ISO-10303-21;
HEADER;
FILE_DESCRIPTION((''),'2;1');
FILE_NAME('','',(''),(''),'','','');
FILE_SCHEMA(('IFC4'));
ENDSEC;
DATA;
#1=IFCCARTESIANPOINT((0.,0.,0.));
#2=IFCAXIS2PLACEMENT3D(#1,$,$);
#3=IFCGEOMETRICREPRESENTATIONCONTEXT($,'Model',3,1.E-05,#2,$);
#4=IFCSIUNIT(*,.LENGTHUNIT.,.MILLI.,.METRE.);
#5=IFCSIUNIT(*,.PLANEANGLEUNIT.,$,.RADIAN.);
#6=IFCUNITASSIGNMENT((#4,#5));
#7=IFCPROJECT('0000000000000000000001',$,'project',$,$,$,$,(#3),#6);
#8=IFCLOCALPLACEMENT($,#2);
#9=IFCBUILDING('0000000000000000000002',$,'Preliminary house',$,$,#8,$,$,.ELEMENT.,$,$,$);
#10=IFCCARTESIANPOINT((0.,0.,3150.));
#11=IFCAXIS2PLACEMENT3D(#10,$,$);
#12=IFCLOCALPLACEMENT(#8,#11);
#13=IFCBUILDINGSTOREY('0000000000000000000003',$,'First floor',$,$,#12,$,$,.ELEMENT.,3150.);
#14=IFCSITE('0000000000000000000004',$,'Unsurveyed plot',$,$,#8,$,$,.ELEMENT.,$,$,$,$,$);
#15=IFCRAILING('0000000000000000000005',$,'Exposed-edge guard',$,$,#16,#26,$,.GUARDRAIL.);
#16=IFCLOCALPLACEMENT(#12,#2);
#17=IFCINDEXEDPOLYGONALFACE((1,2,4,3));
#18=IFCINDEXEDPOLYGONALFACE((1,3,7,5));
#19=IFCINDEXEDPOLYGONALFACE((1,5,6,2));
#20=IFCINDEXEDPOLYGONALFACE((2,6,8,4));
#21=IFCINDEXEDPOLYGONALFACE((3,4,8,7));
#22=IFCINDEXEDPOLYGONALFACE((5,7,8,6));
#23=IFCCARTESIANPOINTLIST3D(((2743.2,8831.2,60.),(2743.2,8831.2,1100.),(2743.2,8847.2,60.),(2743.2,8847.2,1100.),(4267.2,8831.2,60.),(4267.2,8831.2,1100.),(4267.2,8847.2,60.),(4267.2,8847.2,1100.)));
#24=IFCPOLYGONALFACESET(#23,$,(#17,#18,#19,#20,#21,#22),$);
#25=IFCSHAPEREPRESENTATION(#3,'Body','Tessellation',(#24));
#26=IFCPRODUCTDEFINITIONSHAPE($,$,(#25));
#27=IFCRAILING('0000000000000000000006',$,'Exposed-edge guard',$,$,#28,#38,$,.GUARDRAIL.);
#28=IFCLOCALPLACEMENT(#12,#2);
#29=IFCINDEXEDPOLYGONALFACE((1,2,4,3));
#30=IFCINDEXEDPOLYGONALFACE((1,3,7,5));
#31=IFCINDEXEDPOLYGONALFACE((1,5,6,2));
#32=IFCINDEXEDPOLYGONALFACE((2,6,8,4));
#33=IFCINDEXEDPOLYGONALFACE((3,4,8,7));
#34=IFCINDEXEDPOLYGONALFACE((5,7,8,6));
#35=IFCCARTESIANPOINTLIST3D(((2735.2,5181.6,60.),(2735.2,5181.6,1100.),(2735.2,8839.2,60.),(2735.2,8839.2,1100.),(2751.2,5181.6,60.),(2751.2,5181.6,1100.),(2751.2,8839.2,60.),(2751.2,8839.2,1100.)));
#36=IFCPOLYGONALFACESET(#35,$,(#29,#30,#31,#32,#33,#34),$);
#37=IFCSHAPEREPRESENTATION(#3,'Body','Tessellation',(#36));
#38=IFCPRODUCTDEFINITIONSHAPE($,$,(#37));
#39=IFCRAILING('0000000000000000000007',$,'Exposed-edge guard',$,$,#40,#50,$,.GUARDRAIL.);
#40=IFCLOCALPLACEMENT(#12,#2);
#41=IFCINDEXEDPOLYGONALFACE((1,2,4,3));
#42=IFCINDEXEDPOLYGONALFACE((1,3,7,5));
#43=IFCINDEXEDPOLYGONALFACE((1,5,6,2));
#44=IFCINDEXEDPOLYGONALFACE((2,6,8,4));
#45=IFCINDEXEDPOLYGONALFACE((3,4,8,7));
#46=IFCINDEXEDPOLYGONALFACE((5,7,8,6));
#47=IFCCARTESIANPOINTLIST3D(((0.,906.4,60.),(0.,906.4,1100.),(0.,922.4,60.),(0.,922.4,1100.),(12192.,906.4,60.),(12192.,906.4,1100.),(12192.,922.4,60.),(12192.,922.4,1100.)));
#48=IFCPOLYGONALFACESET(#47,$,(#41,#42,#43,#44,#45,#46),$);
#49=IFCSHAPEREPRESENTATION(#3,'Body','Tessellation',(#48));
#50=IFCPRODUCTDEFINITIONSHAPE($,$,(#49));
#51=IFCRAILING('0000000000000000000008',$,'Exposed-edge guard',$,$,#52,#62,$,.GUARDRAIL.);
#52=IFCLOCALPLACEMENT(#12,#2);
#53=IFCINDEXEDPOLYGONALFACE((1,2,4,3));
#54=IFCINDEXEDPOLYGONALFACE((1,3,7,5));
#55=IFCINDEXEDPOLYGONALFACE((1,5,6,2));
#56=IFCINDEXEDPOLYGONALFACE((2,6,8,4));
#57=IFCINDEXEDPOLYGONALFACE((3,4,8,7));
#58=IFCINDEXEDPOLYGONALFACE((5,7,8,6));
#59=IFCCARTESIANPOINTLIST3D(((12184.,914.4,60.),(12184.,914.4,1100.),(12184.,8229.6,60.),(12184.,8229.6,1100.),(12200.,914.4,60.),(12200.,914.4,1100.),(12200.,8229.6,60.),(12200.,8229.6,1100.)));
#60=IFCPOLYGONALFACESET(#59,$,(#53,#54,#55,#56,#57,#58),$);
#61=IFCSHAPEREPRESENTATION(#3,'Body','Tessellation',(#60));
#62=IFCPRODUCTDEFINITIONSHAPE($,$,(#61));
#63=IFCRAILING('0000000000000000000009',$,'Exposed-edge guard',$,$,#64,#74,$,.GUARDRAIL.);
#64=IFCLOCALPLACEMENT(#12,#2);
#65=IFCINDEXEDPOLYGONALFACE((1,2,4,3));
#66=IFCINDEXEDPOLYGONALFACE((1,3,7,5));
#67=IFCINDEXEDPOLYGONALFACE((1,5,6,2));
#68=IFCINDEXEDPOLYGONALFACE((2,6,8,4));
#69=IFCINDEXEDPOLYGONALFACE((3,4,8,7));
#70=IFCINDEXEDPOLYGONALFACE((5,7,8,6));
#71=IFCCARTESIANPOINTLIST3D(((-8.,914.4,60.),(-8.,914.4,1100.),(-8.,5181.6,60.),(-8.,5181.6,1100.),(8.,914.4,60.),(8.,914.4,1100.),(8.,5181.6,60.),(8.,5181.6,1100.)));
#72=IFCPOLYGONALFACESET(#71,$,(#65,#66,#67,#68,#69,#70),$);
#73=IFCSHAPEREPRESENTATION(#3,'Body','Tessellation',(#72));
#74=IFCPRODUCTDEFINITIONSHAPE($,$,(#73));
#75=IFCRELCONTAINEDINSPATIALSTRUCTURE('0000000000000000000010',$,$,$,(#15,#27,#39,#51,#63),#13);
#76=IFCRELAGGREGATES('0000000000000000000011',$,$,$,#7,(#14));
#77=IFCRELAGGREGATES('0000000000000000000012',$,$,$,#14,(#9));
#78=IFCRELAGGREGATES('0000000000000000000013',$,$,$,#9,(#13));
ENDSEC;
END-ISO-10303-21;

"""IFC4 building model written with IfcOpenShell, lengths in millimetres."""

from ifc_helpers import new_model, si_unit, frame, origin, place, context, project, spatial, polyline, outline, extrude, element, save


model = new_model("IFC4")

# Units and contexts
model_context = context("Model", 3, precision=1e-05, world=origin())
ifc_project = project(units=[si_unit("LENGTHUNIT", "METRE", prefix="MILLI"), si_unit("PLANEANGLEUNIT", "RADIAN")], contexts=[model_context])

# Site, building, storey
placement_1 = place(None, origin())
site = spatial("IfcSite", under=ifc_project, at=placement_1, Name="Unsurveyed plot", CompositionType="ELEMENT")
building = spatial("IfcBuilding", under=site, at=placement_1, Name="Preliminary house", CompositionType="ELEMENT")
placement_2 = place(placement_1, frame((0.0, 0.0, 3150.0)))
storey = spatial("IfcBuildingStorey", under=building, at=placement_2, Name="First floor", CompositionType="ELEMENT", Elevation=3150.0)

# Railings
element("IfcRailing", 1, at=placement_2, inside=storey, Name="Exposed-edge guard", PredefinedType="GUARDRAIL", context=model_context, shape_type="SweptSolid", body=[
    extrude(outline(polyline([(2743.2, 8831.2), (2743.2, 8847.2), (4267.2, 8847.2), (4267.2, 8831.2), (2743.2, 8831.2)])), frame((0.0, 0.0, 60.0)), (0.0, 0.0, 1.0), 1040.0),
])
element("IfcRailing", 2, at=placement_2, inside=storey, Name="Exposed-edge guard", PredefinedType="GUARDRAIL", context=model_context, shape_type="SweptSolid", body=[
    extrude(outline(polyline([(2751.2, 5181.6), (2735.2, 5181.6), (2735.2, 8839.2), (2751.2, 8839.2), (2751.2, 5181.6)])), frame((0.0, 0.0, 60.0)), (0.0, 0.0, 1.0), 1040.0),
])
element("IfcRailing", 3, at=placement_2, inside=storey, Name="Exposed-edge guard", PredefinedType="GUARDRAIL", context=model_context, shape_type="SweptSolid", body=[
    extrude(outline(polyline([(0.0, 906.4), (0.0, 922.4), (12192.0, 922.4), (12192.0, 906.4), (0.0, 906.4)])), frame((0.0, 0.0, 60.0)), (0.0, 0.0, 1.0), 1040.0),
])
element("IfcRailing", 4, at=placement_2, inside=storey, Name="Exposed-edge guard", PredefinedType="GUARDRAIL", context=model_context, shape_type="SweptSolid", body=[
    extrude(outline(polyline([(12200.0, 914.4), (12184.0, 914.4), (12184.0, 8229.6), (12200.0, 8229.6), (12200.0, 914.4)])), frame((0.0, 0.0, 60.0)), (0.0, 0.0, 1.0), 1040.0),
])
element("IfcRailing", 5, at=placement_2, inside=storey, Name="Exposed-edge guard", PredefinedType="GUARDRAIL", context=model_context, shape_type="SweptSolid", body=[
    extrude(outline(polyline([(8.0, 914.4), (-8.0, 914.4), (-8.0, 5181.6), (8.0, 5181.6), (8.0, 914.4)])), frame((0.0, 0.0, 60.0)), (0.0, 0.0, 1.0), 1040.0),
])

save(model, "model.ifc")
